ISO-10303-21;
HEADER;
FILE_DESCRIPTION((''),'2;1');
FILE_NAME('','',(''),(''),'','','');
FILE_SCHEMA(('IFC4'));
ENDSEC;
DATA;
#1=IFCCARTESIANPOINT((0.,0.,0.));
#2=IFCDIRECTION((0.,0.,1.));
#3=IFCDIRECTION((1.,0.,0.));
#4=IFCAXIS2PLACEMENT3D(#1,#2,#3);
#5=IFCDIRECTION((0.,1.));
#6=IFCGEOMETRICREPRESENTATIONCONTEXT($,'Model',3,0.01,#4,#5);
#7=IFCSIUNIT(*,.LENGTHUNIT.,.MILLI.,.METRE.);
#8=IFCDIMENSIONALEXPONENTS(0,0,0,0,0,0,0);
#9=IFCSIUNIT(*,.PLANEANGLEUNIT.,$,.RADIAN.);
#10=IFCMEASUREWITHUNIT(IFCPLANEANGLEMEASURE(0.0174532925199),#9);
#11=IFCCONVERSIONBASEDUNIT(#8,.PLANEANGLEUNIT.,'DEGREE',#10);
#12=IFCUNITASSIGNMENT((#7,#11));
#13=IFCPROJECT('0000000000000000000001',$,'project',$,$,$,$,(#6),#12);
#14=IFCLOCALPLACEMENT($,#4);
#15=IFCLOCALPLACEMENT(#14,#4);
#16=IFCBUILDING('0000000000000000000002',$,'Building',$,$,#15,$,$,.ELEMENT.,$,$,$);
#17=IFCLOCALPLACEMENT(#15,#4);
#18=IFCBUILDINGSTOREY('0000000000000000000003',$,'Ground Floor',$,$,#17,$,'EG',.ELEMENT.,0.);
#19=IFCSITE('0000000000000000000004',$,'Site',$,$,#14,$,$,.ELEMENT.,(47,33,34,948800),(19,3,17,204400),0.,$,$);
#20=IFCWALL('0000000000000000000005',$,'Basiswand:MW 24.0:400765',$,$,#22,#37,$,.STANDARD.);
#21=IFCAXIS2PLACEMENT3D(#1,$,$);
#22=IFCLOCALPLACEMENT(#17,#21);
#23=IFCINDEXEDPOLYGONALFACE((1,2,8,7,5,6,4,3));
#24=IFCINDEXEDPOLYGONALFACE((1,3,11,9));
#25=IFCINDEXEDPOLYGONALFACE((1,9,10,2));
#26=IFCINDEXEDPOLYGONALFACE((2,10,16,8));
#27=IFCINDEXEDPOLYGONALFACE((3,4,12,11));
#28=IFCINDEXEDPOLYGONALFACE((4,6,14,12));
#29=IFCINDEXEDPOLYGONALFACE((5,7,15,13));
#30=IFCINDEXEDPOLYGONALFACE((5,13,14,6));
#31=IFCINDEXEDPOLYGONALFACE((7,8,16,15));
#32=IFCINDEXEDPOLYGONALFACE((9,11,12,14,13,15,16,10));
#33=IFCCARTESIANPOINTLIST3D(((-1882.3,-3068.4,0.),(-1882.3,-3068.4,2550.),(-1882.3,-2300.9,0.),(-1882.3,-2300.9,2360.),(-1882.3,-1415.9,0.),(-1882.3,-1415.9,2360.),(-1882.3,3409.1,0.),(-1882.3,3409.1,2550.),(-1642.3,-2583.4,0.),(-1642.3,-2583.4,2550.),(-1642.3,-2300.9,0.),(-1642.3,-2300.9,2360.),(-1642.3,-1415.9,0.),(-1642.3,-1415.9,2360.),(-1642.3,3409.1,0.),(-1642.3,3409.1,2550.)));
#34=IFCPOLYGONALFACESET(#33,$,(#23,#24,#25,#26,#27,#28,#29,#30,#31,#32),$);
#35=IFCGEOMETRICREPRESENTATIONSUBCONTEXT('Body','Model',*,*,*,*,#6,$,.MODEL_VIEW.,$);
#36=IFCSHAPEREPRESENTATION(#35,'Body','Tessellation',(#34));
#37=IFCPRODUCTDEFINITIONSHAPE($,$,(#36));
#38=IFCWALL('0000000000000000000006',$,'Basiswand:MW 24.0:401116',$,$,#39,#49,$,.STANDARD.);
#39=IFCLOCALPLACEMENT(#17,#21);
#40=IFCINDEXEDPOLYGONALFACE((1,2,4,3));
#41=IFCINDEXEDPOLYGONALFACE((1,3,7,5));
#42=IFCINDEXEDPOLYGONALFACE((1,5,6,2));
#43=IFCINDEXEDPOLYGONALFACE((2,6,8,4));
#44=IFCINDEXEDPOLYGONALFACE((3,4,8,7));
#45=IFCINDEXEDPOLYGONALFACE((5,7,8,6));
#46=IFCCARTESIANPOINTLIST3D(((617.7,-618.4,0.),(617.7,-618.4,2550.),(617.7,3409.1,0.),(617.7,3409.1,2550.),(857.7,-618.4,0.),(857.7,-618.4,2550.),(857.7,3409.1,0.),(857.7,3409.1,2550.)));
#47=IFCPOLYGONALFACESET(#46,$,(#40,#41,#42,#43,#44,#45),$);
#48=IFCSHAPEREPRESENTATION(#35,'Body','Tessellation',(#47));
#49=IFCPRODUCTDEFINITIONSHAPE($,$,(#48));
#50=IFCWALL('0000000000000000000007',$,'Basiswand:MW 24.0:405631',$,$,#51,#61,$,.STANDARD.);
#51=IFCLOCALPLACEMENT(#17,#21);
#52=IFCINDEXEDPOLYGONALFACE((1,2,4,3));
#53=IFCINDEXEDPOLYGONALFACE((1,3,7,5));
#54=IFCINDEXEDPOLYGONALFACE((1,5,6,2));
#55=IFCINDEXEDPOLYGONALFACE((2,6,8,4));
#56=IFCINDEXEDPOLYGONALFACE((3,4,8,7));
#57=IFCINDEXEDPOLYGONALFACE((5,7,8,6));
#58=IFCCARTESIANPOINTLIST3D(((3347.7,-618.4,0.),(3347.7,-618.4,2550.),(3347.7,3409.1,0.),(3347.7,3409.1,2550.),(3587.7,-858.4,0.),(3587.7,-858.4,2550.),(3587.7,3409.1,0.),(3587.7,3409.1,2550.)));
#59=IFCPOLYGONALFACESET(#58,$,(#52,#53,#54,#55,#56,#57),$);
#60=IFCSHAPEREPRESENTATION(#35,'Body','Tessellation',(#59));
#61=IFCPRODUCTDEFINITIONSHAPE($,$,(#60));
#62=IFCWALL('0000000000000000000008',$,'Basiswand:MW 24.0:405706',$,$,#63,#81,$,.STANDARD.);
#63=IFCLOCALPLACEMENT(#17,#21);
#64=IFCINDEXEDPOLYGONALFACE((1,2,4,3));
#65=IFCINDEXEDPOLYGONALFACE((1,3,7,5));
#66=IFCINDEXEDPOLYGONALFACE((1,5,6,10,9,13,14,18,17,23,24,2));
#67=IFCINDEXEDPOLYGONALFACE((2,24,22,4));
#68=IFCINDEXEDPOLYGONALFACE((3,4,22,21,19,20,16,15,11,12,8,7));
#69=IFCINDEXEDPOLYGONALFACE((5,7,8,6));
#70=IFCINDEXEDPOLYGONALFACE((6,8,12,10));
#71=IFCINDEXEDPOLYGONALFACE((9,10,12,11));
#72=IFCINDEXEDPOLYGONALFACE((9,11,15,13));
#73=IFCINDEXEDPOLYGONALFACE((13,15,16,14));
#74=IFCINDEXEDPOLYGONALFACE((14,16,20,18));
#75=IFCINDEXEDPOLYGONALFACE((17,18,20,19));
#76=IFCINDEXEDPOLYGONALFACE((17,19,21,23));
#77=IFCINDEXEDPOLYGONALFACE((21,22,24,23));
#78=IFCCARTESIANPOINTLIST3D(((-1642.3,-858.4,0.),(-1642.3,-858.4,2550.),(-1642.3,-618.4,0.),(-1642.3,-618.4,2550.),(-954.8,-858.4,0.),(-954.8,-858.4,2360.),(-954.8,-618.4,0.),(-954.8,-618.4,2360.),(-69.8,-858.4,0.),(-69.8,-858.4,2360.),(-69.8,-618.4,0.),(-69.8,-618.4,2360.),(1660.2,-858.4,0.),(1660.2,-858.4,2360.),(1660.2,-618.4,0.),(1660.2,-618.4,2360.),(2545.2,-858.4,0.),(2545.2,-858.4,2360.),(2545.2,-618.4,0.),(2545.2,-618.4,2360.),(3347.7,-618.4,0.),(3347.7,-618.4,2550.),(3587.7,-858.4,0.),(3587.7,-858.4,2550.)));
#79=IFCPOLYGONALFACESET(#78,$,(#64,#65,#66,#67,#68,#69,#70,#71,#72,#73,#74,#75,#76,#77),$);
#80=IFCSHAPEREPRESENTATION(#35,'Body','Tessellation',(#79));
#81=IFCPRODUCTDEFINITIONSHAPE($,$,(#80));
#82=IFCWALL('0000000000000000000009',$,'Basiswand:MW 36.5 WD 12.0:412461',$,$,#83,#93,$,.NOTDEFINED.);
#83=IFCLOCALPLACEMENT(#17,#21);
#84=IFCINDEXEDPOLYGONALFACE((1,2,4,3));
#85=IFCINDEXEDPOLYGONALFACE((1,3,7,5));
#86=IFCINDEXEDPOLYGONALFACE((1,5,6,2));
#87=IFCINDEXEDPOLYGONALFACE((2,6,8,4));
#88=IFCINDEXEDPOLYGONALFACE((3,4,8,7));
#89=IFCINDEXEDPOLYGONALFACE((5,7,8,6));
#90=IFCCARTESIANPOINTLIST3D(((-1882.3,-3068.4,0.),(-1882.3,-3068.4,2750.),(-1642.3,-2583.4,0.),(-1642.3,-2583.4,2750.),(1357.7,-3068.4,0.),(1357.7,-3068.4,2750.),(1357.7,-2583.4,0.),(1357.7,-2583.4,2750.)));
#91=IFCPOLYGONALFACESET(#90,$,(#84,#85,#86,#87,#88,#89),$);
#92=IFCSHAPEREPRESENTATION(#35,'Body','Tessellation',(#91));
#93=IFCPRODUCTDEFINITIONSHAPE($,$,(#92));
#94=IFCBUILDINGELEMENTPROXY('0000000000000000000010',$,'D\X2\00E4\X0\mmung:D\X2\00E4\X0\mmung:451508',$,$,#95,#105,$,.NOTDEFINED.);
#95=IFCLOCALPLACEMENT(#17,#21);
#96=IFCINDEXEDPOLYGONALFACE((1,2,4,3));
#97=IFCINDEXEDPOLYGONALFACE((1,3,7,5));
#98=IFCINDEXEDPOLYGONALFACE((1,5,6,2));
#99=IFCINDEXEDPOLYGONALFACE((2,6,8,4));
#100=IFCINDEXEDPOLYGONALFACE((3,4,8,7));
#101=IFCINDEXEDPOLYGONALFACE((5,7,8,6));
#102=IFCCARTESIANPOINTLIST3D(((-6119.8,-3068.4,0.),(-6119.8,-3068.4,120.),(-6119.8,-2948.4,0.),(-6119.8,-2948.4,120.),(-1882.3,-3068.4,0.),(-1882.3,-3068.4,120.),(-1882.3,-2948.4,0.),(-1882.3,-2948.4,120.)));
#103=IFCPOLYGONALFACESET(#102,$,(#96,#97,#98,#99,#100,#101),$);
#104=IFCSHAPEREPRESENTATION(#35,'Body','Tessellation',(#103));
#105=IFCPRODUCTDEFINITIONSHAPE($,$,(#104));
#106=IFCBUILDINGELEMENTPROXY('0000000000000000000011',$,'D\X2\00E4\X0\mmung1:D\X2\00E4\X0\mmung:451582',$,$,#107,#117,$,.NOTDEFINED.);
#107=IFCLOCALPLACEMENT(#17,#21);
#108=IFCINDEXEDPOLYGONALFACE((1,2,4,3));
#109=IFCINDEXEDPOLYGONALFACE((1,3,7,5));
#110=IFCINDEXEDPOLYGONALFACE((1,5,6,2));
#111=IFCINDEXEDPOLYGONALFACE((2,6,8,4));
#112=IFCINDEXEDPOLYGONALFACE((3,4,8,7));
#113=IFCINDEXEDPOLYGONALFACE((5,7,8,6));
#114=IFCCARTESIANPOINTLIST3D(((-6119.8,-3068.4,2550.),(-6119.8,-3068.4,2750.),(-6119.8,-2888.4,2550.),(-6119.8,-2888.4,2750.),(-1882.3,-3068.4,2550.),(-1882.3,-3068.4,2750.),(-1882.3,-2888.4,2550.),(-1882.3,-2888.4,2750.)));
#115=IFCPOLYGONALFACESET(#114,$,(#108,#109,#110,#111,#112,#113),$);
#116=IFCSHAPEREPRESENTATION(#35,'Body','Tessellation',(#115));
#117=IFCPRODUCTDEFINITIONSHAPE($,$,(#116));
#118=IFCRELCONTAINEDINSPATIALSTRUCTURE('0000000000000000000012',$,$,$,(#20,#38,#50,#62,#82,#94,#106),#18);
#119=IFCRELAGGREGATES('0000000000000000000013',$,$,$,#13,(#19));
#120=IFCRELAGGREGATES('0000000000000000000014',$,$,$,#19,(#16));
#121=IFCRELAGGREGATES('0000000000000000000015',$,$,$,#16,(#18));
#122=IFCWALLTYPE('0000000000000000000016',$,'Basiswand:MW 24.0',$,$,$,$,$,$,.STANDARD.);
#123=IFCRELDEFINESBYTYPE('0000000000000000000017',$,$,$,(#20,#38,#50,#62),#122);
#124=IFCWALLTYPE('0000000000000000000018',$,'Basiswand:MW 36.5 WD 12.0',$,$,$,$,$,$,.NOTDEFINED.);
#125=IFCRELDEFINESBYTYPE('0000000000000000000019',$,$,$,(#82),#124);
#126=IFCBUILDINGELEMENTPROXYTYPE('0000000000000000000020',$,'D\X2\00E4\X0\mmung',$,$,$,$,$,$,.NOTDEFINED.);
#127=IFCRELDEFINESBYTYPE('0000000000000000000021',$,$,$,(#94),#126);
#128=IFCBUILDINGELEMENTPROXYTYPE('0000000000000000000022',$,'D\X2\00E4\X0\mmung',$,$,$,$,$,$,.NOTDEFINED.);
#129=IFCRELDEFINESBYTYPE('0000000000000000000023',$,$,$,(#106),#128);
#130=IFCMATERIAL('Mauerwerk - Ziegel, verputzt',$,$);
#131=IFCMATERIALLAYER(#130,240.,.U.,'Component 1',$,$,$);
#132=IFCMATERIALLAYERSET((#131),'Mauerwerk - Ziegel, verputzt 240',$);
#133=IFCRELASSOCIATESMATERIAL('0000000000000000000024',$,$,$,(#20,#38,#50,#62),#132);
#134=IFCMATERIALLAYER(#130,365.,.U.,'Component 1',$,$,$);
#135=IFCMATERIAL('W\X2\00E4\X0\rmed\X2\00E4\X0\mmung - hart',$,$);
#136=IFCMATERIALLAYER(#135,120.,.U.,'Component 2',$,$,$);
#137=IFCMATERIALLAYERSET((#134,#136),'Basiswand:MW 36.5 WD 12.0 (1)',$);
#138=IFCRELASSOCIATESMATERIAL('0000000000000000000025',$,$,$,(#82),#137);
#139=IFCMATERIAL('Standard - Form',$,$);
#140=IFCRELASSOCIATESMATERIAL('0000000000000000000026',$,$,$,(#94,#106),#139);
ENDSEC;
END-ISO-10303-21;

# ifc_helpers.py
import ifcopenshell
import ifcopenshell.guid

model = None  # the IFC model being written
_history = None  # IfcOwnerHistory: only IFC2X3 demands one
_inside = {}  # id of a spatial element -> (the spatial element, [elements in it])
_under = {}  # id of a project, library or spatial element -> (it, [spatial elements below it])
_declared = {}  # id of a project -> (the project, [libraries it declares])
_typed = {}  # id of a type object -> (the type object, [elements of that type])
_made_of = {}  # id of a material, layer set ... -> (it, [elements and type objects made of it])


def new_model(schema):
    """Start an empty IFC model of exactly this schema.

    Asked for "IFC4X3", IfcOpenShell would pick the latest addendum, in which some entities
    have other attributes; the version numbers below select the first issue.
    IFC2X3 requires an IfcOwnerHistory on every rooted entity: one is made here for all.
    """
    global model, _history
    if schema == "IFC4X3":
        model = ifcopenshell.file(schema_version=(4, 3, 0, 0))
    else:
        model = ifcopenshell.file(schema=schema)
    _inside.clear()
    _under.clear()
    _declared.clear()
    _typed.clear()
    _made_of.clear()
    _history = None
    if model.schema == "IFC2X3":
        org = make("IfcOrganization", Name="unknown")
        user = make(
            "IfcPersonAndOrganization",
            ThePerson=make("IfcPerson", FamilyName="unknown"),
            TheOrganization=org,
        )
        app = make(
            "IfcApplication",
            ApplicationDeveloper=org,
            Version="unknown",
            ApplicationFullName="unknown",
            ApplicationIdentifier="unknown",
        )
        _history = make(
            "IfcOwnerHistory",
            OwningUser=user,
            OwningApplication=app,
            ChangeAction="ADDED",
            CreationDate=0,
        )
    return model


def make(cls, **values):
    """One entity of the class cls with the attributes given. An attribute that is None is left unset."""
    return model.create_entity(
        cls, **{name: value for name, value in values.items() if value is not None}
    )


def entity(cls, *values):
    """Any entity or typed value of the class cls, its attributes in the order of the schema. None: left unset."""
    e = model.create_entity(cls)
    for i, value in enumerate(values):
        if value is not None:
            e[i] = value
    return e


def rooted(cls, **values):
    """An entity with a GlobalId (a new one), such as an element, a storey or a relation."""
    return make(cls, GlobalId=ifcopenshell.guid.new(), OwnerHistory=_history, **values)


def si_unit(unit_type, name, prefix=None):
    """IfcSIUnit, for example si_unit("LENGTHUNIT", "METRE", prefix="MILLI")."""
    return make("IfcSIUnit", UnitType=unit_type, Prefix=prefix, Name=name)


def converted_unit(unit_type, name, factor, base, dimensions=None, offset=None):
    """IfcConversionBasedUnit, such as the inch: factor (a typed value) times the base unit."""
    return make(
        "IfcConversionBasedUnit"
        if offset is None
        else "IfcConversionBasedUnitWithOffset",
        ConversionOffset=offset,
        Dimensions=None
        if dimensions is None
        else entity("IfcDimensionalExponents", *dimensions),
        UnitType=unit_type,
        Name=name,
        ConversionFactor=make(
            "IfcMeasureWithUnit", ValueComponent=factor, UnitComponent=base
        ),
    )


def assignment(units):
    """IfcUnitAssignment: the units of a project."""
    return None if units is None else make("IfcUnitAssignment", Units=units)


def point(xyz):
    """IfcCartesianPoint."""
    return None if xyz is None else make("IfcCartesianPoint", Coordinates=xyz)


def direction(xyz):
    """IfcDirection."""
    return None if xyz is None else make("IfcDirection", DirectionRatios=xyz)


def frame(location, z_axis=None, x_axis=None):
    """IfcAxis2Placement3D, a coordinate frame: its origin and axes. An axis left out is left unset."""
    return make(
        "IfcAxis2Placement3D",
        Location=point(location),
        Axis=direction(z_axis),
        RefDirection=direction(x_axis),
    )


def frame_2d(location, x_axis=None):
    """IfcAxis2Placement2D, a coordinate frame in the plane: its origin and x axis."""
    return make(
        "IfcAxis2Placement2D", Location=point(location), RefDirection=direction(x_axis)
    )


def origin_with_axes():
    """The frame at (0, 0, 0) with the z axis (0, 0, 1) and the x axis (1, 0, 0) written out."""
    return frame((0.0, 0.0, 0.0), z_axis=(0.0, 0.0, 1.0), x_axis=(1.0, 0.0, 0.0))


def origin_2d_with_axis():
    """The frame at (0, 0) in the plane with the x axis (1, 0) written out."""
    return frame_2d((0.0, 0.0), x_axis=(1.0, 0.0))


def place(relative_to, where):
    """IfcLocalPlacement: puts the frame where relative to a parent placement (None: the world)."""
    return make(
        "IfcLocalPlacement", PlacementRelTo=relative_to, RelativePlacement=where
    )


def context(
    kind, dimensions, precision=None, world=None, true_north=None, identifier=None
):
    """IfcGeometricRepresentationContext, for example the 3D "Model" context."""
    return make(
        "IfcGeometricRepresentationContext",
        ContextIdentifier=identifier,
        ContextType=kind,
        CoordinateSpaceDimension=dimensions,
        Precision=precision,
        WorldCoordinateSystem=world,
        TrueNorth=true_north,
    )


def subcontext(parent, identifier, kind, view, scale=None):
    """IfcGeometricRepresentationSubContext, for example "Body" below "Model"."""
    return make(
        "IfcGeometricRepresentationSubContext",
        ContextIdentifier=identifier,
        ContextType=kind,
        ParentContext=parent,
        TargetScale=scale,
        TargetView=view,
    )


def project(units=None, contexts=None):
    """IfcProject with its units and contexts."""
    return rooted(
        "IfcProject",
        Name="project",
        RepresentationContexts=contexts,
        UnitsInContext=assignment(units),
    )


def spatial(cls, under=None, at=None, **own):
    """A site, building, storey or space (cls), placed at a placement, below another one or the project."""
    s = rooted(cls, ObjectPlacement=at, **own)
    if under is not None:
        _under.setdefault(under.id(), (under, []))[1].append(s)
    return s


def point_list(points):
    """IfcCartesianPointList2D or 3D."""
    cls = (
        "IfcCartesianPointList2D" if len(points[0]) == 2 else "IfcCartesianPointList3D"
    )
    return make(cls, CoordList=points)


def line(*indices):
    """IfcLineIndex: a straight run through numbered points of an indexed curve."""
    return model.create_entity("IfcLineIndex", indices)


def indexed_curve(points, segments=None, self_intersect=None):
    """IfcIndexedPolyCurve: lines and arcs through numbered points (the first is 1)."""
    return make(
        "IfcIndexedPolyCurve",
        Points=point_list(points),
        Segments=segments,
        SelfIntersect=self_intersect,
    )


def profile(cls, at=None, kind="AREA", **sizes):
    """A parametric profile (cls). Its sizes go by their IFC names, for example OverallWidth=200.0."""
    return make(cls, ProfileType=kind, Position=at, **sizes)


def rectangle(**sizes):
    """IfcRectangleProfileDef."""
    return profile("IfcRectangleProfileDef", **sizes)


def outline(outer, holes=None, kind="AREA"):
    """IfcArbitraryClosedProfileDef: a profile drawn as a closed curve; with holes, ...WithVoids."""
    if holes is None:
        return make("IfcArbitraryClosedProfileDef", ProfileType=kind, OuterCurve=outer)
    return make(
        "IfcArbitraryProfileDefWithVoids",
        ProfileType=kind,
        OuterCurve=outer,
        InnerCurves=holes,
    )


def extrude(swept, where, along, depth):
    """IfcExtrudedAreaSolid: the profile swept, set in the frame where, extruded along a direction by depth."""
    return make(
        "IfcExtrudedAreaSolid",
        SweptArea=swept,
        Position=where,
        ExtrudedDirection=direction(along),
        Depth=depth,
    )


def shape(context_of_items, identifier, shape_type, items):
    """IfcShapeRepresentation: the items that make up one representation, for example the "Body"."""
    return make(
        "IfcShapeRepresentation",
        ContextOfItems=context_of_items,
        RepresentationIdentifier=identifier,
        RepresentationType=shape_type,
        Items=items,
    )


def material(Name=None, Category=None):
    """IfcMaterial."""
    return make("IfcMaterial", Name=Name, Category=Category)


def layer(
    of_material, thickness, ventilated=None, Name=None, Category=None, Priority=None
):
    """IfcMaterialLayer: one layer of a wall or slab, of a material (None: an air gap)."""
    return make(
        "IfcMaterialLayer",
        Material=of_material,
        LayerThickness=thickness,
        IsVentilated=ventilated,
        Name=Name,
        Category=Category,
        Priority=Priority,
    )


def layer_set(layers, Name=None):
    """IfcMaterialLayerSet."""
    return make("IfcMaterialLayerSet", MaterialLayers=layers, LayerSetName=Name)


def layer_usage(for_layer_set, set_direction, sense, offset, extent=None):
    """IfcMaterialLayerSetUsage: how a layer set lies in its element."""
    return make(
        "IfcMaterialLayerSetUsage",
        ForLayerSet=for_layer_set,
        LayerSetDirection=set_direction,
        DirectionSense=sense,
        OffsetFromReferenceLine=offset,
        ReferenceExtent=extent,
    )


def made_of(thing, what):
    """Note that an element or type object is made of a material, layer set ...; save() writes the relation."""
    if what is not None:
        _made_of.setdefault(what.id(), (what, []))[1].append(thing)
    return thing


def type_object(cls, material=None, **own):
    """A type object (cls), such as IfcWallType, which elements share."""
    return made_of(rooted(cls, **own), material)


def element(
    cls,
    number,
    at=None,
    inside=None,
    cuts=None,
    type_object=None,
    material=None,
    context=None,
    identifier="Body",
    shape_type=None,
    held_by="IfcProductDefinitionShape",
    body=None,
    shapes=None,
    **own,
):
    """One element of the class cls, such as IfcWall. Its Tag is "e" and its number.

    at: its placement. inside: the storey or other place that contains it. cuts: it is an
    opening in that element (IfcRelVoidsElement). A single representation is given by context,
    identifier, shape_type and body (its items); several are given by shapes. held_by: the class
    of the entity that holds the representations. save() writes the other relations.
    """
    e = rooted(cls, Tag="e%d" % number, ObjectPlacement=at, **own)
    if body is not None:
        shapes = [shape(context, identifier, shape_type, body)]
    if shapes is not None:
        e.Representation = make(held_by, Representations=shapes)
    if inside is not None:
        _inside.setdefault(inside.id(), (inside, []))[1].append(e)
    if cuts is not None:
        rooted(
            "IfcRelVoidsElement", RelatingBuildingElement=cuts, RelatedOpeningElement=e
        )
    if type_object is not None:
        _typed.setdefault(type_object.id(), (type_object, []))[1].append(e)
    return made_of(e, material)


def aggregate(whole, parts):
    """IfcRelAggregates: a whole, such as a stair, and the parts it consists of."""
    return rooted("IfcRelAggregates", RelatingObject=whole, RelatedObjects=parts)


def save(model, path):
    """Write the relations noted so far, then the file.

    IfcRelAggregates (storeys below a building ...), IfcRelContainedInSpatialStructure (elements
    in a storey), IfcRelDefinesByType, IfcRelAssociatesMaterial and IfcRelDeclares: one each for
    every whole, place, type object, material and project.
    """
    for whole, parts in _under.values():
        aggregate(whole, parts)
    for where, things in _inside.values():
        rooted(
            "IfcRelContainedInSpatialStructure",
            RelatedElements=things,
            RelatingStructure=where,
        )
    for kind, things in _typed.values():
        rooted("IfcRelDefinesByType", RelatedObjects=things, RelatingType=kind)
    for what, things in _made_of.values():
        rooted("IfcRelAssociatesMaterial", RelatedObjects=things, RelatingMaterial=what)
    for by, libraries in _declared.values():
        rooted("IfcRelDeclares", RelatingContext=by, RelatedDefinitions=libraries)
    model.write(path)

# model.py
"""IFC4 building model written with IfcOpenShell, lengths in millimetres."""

from ifc_helpers import new_model, entity, si_unit, converted_unit, direction, frame, origin_with_axes, origin_2d_with_axis, place, context, subcontext, project, spatial, line, indexed_curve, rectangle, outline, extrude, material, layer, layer_set, layer_usage, type_object, element, save


model = new_model("IFC4")

# Units and contexts
model_context = context("Model", 3, precision=0.01, world=origin_with_axes(), true_north=direction((0.0, 1.0)))
body_context = subcontext(model_context, "Body", "Model", "MODEL_VIEW")
ifc_project = project(units=[si_unit("LENGTHUNIT", "METRE", prefix="MILLI"), converted_unit("PLANEANGLEUNIT", "DEGREE", entity("IfcPlaneAngleMeasure", 0.0174532925199), si_unit("PLANEANGLEUNIT", "RADIAN"), dimensions=[0, 0, 0, 0, 0, 0, 0])], contexts=[model_context])

# Site, building, storey
site_placement = place(None, origin_with_axes())
site = spatial("IfcSite", under=ifc_project, at=site_placement, Name="Site", CompositionType="ELEMENT", RefLatitude=(47, 33, 34, 948800), RefLongitude=(19, 3, 17, 204400), RefElevation=0.0)
building_placement = place(site_placement, origin_with_axes())
building = spatial("IfcBuilding", under=site, at=building_placement, Name="Building", CompositionType="ELEMENT")
storey_placement = place(building_placement, origin_with_axes())
storey = spatial("IfcBuildingStorey", under=building, at=storey_placement, Name="Ground Floor", LongName="EG", CompositionType="ELEMENT", Elevation=0.0)

# Wall, opening
ifc_material_1 = material(Name="Mauerwerk - Ziegel, verputzt")
ifc_layer_1 = layer(ifc_material_1, 240.0, ventilated="UNKNOWN", Name="Component 1")
ifc_layer_set_1 = layer_set([ifc_layer_1], Name="Mauerwerk - Ziegel, verputzt 240")
ifc_layer_usage_1 = layer_usage(ifc_layer_set_1, "AXIS2", "POSITIVE", -120.0)
wall_type_1 = type_object("IfcWallType", Name="Basiswand:MW 24.0", PredefinedType="STANDARD")
wall_1_placement = place(storey_placement, frame((-1762.3, 3409.1, 0.0), z_axis=(0.0, 0.0, 1.0), x_axis=(0.0, -1.0, 0.0)))
wall_1 = element("IfcWall", 1, at=wall_1_placement, inside=storey, type_object=wall_type_1, material=ifc_layer_usage_1, Name="Basiswand:MW 24.0:400765", PredefinedType="STANDARD", context=body_context, shape_type="SweptSolid", body=[
    extrude(outline(indexed_curve([(0.0, -120.0), (6477.5, -120.0), (5992.5, 120.0), (0.0, 120.0)], segments=[line(1, 2, 3, 4, 1)])), origin_with_axes(), (0.0, 0.0, 1.0), 2550.0),
])
opening_1_placement = place(wall_1_placement, frame((5267.5, 0.0, 0.0), z_axis=(0.0, 0.0, 1.0), x_axis=(1.0, 0.0, 0.0)))
element("IfcOpeningElement", 2, at=opening_1_placement, cuts=wall_1, context=body_context, shape_type="SweptSolid", body=[
    extrude(outline(indexed_curve([(-442.5, -2360.0), (442.5, -2360.0), (442.5, 0.0), (-442.5, 0.0)], segments=[line(1, 2, 3, 4, 1)])), frame((0.0, 120.0, 0.0), z_axis=(0.0, -1.0, 0.0), x_axis=(-1.0, 0.0, 0.0)), (0.0, 0.0, 1.0), 240.0),
])

# Walls
ifc_layer_usage_2 = layer_usage(ifc_layer_set_1, "AXIS2", "POSITIVE", -120.0)
wall_2_placement = place(storey_placement, frame((737.7, 3409.1, 0.0), z_axis=(0.0, 0.0, 1.0), x_axis=(0.0, -1.0, 0.0)))
element("IfcWall", 3, at=wall_2_placement, inside=storey, type_object=wall_type_1, material=ifc_layer_usage_2, Name="Basiswand:MW 24.0:401116", PredefinedType="STANDARD", context=body_context, shape_type="SweptSolid", body=[
    extrude(outline(indexed_curve([(0.0, -120.0), (4027.5, -120.0), (4027.5, 120.0), (0.0, 120.0)], segments=[line(1, 2, 3, 4, 1)])), origin_with_axes(), (0.0, 0.0, 1.0), 2550.0),
])
ifc_layer_usage_3 = layer_usage(ifc_layer_set_1, "AXIS2", "POSITIVE", -120.0)
wall_3_placement = place(storey_placement, frame((3467.7, 3409.1, 0.0), z_axis=(0.0, 0.0, 1.0), x_axis=(0.0, -1.0, 0.0)))
element("IfcWall", 4, at=wall_3_placement, inside=storey, type_object=wall_type_1, material=ifc_layer_usage_3, Name="Basiswand:MW 24.0:405631", PredefinedType="STANDARD", context=body_context, shape_type="SweptSolid", body=[
    extrude(outline(indexed_curve([(0.0, -120.0), (4027.5, -120.0), (4267.5, 120.0), (0.0, 120.0)], segments=[line(1, 2, 3, 4, 1)])), origin_with_axes(), (0.0, 0.0, 1.0), 2550.0),
])

# Wall, openings
ifc_layer_usage_4 = layer_usage(ifc_layer_set_1, "AXIS2", "POSITIVE", -120.0)
wall_4_placement = place(storey_placement, frame((3467.7, -738.4, 0.0), z_axis=(0.0, 0.0, 1.0), x_axis=(-1.0, 0.0, 0.0)))
wall_4 = element("IfcWall", 5, at=wall_4_placement, inside=storey, type_object=wall_type_1, material=ifc_layer_usage_4, Name="Basiswand:MW 24.0:405706", PredefinedType="STANDARD", context=body_context, shape_type="SweptSolid", body=[
    extrude(outline(indexed_curve([(120.0, -120.0), (5110.0, -120.0), (5110.0, 120.0), (-120.0, 120.0)], segments=[line(1, 2, 3, 4, 1)])), origin_with_axes(), (0.0, 0.0, 1.0), 2550.0),
])
opening_2_placement = place(wall_4_placement, frame((1365.0, 0.0, 0.0), z_axis=(0.0, 0.0, 1.0), x_axis=(1.0, 0.0, 0.0)))
element("IfcOpeningElement", 6, at=opening_2_placement, cuts=wall_4, context=body_context, shape_type="SweptSolid", body=[
    extrude(outline(indexed_curve([(-442.5, -2360.0), (442.5, -2360.0), (442.5, 0.0), (-442.5, 0.0)], segments=[line(1, 2, 3, 4, 1)])), frame((0.0, 120.0, 0.0), z_axis=(0.0, -1.0, 0.0), x_axis=(-1.0, 0.0, 0.0)), (0.0, 0.0, 1.0), 240.0),
])
opening_3_placement = place(wall_4_placement, frame((3980.0, 0.0, 0.0), z_axis=(0.0, 0.0, 1.0), x_axis=(1.0, 0.0, 0.0)))
element("IfcOpeningElement", 7, at=opening_3_placement, cuts=wall_4, context=body_context, shape_type="SweptSolid", body=[
    extrude(outline(indexed_curve([(-442.5, -2360.0), (442.5, -2360.0), (442.5, 0.0), (-442.5, 0.0)], segments=[line(1, 2, 3, 4, 1)])), frame((0.0, 120.0, 0.0), z_axis=(0.0, -1.0, 0.0), x_axis=(-1.0, 0.0, 0.0)), (0.0, 0.0, 1.0), 240.0),
])

# Wall
ifc_layer_2 = layer(ifc_material_1, 365.0, ventilated="UNKNOWN", Name="Component 1")
ifc_material_2 = material(Name="Wärmedämmung - hart")
ifc_layer_3 = layer(ifc_material_2, 120.0, ventilated="UNKNOWN", Name="Component 2")
ifc_layer_set_2 = layer_set([ifc_layer_2, ifc_layer_3], Name="Basiswand:MW 36.5 WD 12.0 (1)")
ifc_layer_usage_5 = layer_usage(ifc_layer_set_2, "AXIS2", "POSITIVE", -242.5)
wall_type_2 = type_object("IfcWallType", Name="Basiswand:MW 36.5 WD 12.0", PredefinedType="NOTDEFINED")
wall_5_placement = place(storey_placement, frame((1357.7, -2825.9, 0.0), z_axis=(0.0, 0.0, 1.0), x_axis=(-1.0, 0.0, 0.0)))
element("IfcWall", 8, at=wall_5_placement, inside=storey, type_object=wall_type_2, material=ifc_layer_usage_5, Name="Basiswand:MW 36.5 WD 12.0:412461", PredefinedType="NOTDEFINED", context=body_context, shape_type="SweptSolid", body=[
    extrude(outline(indexed_curve([(0.0, -242.5), (3000.0, -242.5), (3240.0, 242.5), (0.0, 242.5)], segments=[line(1, 2, 3, 4, 1)])), origin_with_axes(), (0.0, 0.0, 1.0), 2750.0),
])

# Building element proxies
ifc_material_3 = material(Name="Standard - Form")
building_element_proxy_type_1 = type_object("IfcBuildingElementProxyType", Name="Dämmung", PredefinedType="NOTDEFINED")
proxy_1_placement = place(storey_placement, origin_with_axes())
element("IfcBuildingElementProxy", 9, at=proxy_1_placement, inside=storey, type_object=building_element_proxy_type_1, material=ifc_material_3, Name="Dämmung:Dämmung:451508", PredefinedType="NOTDEFINED", context=body_context, shape_type="SweptSolid", body=[
    extrude(rectangle(XDim=4237.5, YDim=120.0, at=origin_2d_with_axis()), frame((-4001.0, -3008.4, 0.0), z_axis=(0.0, 0.0, 1.0), x_axis=(-1.0, 0.0, 0.0)), (0.0, 0.0, 1.0), 120.0),
])
building_element_proxy_type_2 = type_object("IfcBuildingElementProxyType", Name="Dämmung", PredefinedType="NOTDEFINED")
proxy_2_placement = place(storey_placement, origin_with_axes())
element("IfcBuildingElementProxy", 10, at=proxy_2_placement, inside=storey, type_object=building_element_proxy_type_2, material=ifc_material_3, Name="Dämmung1:Dämmung:451582", PredefinedType="NOTDEFINED", context=body_context, shape_type="SweptSolid", body=[
    extrude(rectangle(XDim=180.0, YDim=4237.5, at=origin_2d_with_axis()), frame((-4001.0, -2978.4, 2550.0), z_axis=(0.0, 0.0, 1.0), x_axis=(0.0, -1.0, 0.0)), (0.0, 0.0, 1.0), 200.0),
])

save(model, "model.ifc")
